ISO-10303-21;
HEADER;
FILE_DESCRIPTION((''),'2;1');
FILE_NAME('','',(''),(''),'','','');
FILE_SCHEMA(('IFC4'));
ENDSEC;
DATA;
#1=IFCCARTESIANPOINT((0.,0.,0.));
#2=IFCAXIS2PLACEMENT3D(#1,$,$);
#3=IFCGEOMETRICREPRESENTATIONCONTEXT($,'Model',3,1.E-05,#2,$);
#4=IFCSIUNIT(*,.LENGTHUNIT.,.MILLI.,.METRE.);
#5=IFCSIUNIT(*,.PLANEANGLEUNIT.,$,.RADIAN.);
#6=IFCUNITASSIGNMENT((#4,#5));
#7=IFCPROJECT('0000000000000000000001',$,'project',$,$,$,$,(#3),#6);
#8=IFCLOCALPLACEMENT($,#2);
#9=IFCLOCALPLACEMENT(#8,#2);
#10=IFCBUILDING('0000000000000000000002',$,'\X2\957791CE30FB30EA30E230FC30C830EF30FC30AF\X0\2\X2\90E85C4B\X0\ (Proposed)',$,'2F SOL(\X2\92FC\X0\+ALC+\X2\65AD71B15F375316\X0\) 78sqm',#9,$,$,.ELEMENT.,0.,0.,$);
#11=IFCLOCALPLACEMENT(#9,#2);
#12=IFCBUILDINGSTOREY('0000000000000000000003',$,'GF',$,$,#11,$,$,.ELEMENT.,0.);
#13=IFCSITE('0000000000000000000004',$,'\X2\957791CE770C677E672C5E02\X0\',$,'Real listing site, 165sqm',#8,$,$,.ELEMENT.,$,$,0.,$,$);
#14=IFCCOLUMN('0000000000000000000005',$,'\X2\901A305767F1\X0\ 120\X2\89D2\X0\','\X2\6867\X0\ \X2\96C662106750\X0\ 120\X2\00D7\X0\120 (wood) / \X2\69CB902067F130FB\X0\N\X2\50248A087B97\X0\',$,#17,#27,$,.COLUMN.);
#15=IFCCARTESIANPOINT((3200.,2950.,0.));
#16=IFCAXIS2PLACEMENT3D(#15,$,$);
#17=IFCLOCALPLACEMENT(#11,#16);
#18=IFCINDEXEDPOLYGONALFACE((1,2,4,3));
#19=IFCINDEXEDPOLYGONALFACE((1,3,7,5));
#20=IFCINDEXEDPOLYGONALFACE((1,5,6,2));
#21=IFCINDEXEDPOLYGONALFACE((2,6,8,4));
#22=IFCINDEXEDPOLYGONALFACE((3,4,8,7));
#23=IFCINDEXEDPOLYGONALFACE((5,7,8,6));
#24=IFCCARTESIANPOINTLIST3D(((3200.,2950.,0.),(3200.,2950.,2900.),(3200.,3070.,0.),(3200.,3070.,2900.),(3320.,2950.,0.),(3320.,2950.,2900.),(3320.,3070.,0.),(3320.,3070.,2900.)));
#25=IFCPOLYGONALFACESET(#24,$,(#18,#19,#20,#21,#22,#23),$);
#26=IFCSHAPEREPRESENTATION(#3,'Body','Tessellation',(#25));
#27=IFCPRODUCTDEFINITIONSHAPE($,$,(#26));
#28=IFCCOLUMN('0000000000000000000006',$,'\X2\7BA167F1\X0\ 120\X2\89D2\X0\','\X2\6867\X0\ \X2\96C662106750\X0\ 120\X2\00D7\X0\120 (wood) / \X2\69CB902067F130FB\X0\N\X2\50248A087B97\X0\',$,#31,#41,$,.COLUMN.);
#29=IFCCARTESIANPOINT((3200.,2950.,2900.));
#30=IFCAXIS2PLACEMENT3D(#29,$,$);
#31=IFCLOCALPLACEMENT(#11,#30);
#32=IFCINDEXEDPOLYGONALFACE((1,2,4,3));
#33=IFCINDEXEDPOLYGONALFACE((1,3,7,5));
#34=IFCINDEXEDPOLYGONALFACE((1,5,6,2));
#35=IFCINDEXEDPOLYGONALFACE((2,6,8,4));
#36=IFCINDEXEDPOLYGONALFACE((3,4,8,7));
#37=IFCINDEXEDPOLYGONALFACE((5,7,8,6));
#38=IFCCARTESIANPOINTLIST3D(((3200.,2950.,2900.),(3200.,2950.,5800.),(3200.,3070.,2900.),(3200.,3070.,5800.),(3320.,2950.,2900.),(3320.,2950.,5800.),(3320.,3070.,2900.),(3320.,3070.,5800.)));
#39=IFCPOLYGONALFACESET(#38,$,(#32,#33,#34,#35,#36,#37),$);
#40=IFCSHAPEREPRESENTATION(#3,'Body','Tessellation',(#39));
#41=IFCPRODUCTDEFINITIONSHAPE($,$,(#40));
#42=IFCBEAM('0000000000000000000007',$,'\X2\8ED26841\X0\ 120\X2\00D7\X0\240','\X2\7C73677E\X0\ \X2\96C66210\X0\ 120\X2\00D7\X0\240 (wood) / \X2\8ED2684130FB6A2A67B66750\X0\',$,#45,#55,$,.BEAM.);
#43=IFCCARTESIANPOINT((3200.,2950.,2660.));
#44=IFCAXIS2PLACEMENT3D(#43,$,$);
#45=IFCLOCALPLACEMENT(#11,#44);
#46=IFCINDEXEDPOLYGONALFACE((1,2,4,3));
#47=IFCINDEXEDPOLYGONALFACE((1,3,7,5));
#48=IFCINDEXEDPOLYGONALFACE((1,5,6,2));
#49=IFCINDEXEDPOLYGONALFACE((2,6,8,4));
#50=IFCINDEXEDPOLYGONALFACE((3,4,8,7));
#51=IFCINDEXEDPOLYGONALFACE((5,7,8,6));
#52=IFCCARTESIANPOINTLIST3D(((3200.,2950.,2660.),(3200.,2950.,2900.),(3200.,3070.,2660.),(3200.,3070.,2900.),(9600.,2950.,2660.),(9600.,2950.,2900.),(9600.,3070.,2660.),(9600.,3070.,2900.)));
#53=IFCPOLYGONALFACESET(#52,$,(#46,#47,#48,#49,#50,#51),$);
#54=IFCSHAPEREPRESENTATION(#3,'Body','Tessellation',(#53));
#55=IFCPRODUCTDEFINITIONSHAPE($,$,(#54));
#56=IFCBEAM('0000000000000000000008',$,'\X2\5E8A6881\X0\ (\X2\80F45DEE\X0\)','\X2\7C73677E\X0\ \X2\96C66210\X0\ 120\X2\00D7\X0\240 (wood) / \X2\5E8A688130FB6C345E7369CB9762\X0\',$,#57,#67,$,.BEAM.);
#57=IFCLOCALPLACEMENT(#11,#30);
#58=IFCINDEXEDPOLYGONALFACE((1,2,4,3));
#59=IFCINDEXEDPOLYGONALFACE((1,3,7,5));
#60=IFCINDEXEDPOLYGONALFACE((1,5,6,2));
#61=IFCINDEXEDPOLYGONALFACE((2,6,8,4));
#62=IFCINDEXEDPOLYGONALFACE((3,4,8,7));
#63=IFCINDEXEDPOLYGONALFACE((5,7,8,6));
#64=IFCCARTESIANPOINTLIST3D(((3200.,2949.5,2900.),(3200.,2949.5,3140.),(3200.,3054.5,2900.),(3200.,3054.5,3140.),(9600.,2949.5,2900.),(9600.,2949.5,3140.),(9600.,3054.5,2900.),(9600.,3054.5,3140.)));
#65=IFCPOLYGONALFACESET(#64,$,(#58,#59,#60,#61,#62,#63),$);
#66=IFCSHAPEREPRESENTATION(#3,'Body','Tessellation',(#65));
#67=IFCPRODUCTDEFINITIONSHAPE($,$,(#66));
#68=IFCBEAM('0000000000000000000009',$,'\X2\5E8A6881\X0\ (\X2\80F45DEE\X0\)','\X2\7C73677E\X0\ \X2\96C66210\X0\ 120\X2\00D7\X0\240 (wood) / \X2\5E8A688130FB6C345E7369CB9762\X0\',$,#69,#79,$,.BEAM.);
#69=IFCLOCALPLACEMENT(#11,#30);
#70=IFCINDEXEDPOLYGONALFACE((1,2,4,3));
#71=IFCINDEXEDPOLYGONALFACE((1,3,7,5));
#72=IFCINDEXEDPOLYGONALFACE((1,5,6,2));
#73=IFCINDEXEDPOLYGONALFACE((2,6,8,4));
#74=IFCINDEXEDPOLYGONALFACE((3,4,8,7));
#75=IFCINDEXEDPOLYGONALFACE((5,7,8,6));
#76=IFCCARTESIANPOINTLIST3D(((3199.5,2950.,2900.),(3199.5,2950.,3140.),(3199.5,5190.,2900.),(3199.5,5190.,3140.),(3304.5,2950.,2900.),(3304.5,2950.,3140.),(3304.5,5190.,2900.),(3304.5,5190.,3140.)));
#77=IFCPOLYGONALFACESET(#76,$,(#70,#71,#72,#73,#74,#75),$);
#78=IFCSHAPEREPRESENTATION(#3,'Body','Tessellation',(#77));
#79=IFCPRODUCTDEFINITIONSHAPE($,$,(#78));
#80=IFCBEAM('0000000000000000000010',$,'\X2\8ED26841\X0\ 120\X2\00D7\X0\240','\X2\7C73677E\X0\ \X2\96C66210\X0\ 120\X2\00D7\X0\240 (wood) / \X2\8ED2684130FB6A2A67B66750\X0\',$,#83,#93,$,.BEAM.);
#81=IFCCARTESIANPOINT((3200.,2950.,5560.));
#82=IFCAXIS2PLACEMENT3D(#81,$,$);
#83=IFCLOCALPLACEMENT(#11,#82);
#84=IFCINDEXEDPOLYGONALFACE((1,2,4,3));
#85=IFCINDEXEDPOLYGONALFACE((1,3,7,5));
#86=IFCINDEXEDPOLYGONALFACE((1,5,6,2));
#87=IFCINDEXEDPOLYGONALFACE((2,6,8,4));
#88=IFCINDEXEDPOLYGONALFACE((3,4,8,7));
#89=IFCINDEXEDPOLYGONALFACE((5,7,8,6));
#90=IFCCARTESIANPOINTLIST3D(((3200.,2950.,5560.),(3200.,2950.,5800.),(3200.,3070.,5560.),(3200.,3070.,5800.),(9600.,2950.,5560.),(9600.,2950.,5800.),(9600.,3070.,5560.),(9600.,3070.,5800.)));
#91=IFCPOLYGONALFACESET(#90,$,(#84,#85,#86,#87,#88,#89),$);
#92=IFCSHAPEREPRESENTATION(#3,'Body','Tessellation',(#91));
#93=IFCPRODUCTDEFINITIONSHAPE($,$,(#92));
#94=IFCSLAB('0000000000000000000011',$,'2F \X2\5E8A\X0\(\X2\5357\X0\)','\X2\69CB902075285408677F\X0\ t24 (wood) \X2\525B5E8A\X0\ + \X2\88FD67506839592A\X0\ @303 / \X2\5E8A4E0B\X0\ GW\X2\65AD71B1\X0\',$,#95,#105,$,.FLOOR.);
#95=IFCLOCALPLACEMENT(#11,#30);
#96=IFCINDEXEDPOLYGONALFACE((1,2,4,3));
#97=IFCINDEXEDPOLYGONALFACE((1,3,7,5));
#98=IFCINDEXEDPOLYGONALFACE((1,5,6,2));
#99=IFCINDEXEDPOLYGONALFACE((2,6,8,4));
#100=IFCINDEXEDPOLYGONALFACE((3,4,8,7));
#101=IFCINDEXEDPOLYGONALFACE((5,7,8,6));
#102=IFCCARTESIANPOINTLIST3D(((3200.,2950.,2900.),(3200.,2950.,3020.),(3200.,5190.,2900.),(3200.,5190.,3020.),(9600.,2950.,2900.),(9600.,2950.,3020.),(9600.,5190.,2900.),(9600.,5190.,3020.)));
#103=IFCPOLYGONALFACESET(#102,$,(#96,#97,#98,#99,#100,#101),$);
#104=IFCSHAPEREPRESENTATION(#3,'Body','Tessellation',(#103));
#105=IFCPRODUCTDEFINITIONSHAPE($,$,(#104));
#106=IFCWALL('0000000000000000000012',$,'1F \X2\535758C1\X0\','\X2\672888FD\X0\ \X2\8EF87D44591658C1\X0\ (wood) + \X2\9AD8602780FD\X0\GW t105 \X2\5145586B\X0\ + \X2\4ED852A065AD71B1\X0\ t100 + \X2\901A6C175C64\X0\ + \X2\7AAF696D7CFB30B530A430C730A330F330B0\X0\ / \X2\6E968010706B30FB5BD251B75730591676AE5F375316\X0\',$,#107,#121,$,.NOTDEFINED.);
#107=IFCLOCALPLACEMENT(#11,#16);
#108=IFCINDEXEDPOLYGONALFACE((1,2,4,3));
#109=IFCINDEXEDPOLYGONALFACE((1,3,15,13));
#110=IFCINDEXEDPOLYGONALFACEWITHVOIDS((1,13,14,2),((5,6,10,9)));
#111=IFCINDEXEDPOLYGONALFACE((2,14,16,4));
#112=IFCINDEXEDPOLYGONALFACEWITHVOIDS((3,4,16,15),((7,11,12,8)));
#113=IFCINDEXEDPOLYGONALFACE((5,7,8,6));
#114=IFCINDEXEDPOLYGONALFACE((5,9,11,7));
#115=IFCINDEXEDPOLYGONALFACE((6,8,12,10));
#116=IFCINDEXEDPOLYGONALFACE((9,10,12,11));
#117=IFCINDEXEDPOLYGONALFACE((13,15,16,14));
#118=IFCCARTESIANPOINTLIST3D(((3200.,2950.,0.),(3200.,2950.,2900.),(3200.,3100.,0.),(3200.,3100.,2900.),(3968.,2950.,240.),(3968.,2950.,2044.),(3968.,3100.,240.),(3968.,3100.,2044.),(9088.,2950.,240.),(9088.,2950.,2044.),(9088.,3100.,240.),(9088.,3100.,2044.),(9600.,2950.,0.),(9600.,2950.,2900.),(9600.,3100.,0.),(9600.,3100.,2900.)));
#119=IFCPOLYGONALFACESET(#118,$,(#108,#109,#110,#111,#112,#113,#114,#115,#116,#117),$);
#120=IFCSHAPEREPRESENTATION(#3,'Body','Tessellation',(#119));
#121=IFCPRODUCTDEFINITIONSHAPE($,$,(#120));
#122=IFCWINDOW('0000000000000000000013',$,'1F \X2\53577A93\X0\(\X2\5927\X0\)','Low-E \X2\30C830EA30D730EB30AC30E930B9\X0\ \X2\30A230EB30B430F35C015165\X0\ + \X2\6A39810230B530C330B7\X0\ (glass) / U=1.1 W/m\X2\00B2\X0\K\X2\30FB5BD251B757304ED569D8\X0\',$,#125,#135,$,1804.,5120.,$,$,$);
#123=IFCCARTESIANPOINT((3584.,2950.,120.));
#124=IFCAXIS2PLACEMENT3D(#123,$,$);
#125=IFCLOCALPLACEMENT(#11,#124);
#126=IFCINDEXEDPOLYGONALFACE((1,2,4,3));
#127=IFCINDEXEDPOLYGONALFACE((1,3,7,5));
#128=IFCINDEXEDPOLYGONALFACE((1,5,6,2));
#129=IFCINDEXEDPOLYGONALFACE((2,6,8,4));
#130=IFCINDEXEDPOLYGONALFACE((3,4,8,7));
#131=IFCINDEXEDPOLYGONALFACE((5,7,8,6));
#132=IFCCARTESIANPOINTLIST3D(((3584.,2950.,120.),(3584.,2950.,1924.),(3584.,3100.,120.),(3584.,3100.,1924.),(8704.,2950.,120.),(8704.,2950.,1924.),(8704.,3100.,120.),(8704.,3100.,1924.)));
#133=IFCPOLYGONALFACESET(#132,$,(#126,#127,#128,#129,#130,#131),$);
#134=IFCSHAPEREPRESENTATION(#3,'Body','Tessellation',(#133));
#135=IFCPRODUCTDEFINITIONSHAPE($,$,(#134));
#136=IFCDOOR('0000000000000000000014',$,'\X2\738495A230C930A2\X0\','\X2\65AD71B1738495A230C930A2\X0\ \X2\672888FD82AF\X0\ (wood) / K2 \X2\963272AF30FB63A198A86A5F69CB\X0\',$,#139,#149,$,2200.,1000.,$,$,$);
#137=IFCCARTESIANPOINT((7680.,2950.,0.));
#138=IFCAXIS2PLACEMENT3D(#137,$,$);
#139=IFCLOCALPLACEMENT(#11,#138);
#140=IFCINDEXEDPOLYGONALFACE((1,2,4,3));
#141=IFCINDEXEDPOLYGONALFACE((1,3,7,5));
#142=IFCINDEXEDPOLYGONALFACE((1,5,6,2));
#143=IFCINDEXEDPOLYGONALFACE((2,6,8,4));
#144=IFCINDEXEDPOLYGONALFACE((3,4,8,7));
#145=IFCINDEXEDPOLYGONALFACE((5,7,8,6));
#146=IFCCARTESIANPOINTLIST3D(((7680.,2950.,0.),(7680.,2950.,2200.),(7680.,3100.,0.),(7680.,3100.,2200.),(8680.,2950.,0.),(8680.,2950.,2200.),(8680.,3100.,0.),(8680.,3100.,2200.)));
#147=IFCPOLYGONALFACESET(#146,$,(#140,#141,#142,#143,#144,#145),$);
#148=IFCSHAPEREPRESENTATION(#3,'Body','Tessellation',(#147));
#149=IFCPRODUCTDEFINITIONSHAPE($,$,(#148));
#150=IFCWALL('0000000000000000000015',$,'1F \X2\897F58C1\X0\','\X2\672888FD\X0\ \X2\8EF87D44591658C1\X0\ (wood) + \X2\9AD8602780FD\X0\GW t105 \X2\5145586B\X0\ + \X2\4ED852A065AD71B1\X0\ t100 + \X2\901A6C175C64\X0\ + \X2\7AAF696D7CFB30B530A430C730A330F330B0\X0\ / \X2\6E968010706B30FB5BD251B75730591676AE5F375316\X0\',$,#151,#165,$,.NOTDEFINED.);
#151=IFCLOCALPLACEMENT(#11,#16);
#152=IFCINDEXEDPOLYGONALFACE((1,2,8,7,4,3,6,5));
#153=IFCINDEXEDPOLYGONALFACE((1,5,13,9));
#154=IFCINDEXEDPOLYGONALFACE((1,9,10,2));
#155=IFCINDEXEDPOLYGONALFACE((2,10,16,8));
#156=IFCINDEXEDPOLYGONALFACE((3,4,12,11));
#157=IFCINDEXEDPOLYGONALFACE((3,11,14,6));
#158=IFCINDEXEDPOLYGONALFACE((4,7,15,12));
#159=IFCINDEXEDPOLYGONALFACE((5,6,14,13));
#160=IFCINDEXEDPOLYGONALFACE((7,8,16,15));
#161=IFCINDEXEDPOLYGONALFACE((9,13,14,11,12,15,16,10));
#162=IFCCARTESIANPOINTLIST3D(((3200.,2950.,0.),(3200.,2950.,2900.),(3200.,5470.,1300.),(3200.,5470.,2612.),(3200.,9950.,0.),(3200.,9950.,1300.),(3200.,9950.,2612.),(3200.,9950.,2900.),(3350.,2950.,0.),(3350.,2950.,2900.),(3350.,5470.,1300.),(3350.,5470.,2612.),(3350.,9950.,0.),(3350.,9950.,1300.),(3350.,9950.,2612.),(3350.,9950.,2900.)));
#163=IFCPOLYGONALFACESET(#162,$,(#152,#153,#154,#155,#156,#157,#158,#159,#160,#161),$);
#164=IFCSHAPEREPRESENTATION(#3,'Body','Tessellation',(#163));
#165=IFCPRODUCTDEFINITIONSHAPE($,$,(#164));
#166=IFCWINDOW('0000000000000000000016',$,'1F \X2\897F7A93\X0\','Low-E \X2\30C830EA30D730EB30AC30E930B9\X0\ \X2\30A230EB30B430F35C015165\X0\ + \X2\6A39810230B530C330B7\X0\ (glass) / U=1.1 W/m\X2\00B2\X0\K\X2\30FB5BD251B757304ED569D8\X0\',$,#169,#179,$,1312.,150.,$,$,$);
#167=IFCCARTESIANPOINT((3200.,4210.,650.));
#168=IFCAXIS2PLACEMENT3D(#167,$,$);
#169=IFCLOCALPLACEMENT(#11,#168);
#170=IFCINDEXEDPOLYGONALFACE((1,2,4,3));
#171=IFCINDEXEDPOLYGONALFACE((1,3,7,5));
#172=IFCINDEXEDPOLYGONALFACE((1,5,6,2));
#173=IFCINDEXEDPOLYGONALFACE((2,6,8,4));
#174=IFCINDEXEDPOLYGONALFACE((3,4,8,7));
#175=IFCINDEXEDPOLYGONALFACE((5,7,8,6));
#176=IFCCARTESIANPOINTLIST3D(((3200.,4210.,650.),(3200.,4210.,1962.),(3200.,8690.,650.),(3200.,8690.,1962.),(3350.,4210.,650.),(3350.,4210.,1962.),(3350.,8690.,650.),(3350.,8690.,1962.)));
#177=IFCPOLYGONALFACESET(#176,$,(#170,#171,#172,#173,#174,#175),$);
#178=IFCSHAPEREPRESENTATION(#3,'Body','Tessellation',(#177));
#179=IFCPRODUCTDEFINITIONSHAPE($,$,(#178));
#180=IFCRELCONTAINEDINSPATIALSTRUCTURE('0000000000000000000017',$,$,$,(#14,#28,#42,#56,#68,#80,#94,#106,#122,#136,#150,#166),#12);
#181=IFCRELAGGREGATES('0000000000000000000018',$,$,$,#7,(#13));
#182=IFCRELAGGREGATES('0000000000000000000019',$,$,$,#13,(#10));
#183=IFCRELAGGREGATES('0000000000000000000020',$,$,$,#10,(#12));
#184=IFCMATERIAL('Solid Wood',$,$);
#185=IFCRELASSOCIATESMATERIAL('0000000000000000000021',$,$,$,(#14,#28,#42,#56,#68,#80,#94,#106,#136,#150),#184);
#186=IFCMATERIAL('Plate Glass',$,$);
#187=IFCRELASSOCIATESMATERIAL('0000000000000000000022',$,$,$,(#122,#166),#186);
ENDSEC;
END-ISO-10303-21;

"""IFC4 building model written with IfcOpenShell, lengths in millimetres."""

from ifc_helpers import new_model, si_unit, frame, frame_2d, origin, place, context, project, spatial, rectangle, extrude, material, element, fill, save


model = new_model("IFC4")

# Units and contexts
model_context = context("Model", 3, precision=1e-05, world=origin())
ifc_project = project(units=[si_unit("LENGTHUNIT", "METRE", prefix="MILLI"), si_unit("PLANEANGLEUNIT", "RADIAN")], contexts=[model_context])

# Site, building, storey
site_placement = place(None, origin())
site = spatial("IfcSite", under=ifc_project, at=site_placement, Name="長野県松本市", ObjectType="Real listing site, 165sqm", CompositionType="ELEMENT", RefElevation=0.0)
building_placement = place(site_placement, origin())
building = spatial("IfcBuilding", under=site, at=building_placement, Name="長野・リモートワーク2部屋 (Proposed)", ObjectType="2F SOL(鋼+ALC+断熱強化) 78sqm", CompositionType="ELEMENT", ElevationOfRefHeight=0.0, ElevationOfTerrain=0.0)
storey_placement = place(building_placement, origin())
storey = spatial("IfcBuildingStorey", under=building, at=storey_placement, Name="GF", CompositionType="ELEMENT", Elevation=0.0)

# Columns
ifc_material_1 = material(Name="Solid Wood")
column_1_placement = place(storey_placement, frame((3200.0, 2950.0, 0.0)))
element("IfcColumn", 1, at=column_1_placement, inside=storey, material=ifc_material_1, Name="通し柱 120角", Description="桧 集成材 120×120 (wood) / 構造柱・N値計算", PredefinedType="COLUMN", context=model_context, shape_type="SweptSolid", body=[
    extrude(rectangle(XDim=120.0, YDim=120.0, at=frame_2d((60.0, 60.0))), frame((3200.0, 2950.0, 0.0)), (0.0, 0.0, 1.0), 2900.0),
])
column_2_placement = place(storey_placement, frame((3200.0, 2950.0, 2900.0)))
element("IfcColumn", 2, at=column_2_placement, inside=storey, material=ifc_material_1, Name="管柱 120角", Description="桧 集成材 120×120 (wood) / 構造柱・N値計算", PredefinedType="COLUMN", context=model_context, shape_type="SweptSolid", body=[
    extrude(rectangle(XDim=120.0, YDim=120.0, at=frame_2d((60.0, 60.0))), frame((3200.0, 2950.0, 2900.0)), (0.0, 0.0, 1.0), 2900.0),
])

# Beams
beam_1_placement = place(storey_placement, frame((3200.0, 2950.0, 2660.0)))
element("IfcBeam", 3, at=beam_1_placement, inside=storey, material=ifc_material_1, Name="軒桁 120×240", Description="米松 集成 120×240 (wood) / 軒桁・横架材", PredefinedType="BEAM", context=model_context, shape_type="SweptSolid", body=[
    extrude(rectangle(XDim=6400.0, YDim=120.0, at=frame_2d((3200.0, 60.0))), frame((3200.0, 2950.0, 2660.0)), (0.0, 0.0, 1.0), 240.0),
])
beam_2_placement = place(storey_placement, frame((3200.0, 2950.0, 2900.0)))
element("IfcBeam", 4, at=beam_2_placement, inside=storey, material=ifc_material_1, Name="床梁 (胴差)", Description="米松 集成 120×240 (wood) / 床梁・水平構面", PredefinedType="BEAM", context=model_context, shape_type="SweptSolid", body=[
    extrude(rectangle(XDim=6400.0, YDim=105.0, at=frame_2d((3200.0, 52.0))), frame((3200.0, 2950.0, 2900.0)), (0.0, 0.0, 1.0), 240.0),
])
beam_3_placement = place(storey_placement, frame((3200.0, 2950.0, 2900.0)))
element("IfcBeam", 5, at=beam_3_placement, inside=storey, material=ifc_material_1, Name="床梁 (胴差)", Description="米松 集成 120×240 (wood) / 床梁・水平構面", PredefinedType="BEAM", context=model_context, shape_type="SweptSolid", body=[
    extrude(rectangle(XDim=105.0, YDim=2240.0, at=frame_2d((52.0, 1120.0))), frame((3200.0, 2950.0, 2900.0)), (0.0, 0.0, 1.0), 240.0),
])
beam_4_placement = place(storey_placement, frame((3200.0, 2950.0, 5560.0)))
element("IfcBeam", 6, at=beam_4_placement, inside=storey, material=ifc_material_1, Name="軒桁 120×240", Description="米松 集成 120×240 (wood) / 軒桁・横架材", PredefinedType="BEAM", context=model_context, shape_type="SweptSolid", body=[
    extrude(rectangle(XDim=6400.0, YDim=120.0, at=frame_2d((3200.0, 60.0))), frame((3200.0, 2950.0, 5560.0)), (0.0, 0.0, 1.0), 240.0),
])

# Slab
slab_1_placement = place(storey_placement, frame((3200.0, 2950.0, 2900.0)))
element("IfcSlab", 7, at=slab_1_placement, inside=storey, material=ifc_material_1, Name="2F 床(南)", Description="構造用合板 t24 (wood) 剛床 + 製材根太 @303 / 床下 GW断熱", PredefinedType="FLOOR", context=model_context, shape_type="SweptSolid", body=[
    extrude(rectangle(XDim=6400.0, YDim=2240.0, at=frame_2d((3200.0, 1120.0))), frame((3200.0, 2950.0, 2900.0)), (0.0, 0.0, 1.0), 120.0),
])

# Wall, openings, window, door
wall_1_placement = place(storey_placement, frame((3200.0, 2950.0, 0.0)))
wall_1 = element("IfcWall", 8, at=wall_1_placement, inside=storey, material=ifc_material_1, Name="1F 南壁", Description="木製 軸組外壁 (wood) + 高性能GW t105 充填 + 付加断熱 t100 + 通気層 + 窯業系サイディング / 準耐火・寒冷地外皮強化", PredefinedType="NOTDEFINED", context=model_context, shape_type="SweptSolid", body=[
    extrude(rectangle(XDim=6400.0, YDim=150.0, at=frame_2d((3200.0, 75.0))), frame((3200.0, 2950.0, 0.0)), (0.0, 0.0, 1.0), 2900.0),
])
opening_1_placement = place(storey_placement, frame((3584.0, 2950.0, 120.0)))
opening_1 = element("IfcOpeningElement", 9, at=opening_1_placement, cuts=wall_1, PredefinedType="NOTDEFINED", context=model_context, shape_type="SweptSolid", body=[
    extrude(rectangle(XDim=5120.0, YDim=150.0, at=frame_2d((2560.0, 75.0))), frame((3584.0, 2950.0, 120.0)), (0.0, 0.0, 1.0), 1804.0),
])
opening_2_placement = place(storey_placement, frame((7680.0, 2950.0, 0.0)))
opening_2 = element("IfcOpeningElement", 10, at=opening_2_placement, cuts=wall_1, PredefinedType="NOTDEFINED", context=model_context, shape_type="SweptSolid", body=[
    extrude(rectangle(XDim=1000.0, YDim=150.0, at=frame_2d((500.0, 75.0))), frame((7680.0, 2950.0, 0.0)), (0.0, 0.0, 1.0), 2200.0),
])
ifc_material_2 = material(Name="Plate Glass")
window_1_placement = place(storey_placement, frame((3584.0, 2950.0, 120.0)))
window_1 = element("IfcWindow", 11, at=window_1_placement, inside=storey, material=ifc_material_2, Name="1F 南窓(大)", Description="Low-E トリプルガラス アルゴン封入 + 樹脂サッシ (glass) / U=1.1 W/m²K・寒冷地仕様", OverallHeight=1804.0, OverallWidth=5120.0, context=model_context, shape_type="SweptSolid", body=[
    extrude(rectangle(XDim=5120.0, YDim=150.0, at=frame_2d((2560.0, 75.0))), frame((3584.0, 2950.0, 120.0)), (0.0, 0.0, 1.0), 1804.0),
])
fill(opening_1, window_1)
door_placement = place(storey_placement, frame((7680.0, 2950.0, 0.0)))
door = element("IfcDoor", 12, at=door_placement, inside=storey, material=ifc_material_1, Name="玄関ドア", Description="断熱玄関ドア 木製芯 (wood) / K2 防犯・採風機構", OverallHeight=2200.0, OverallWidth=1000.0, context=model_context, shape_type="SweptSolid", body=[
    extrude(rectangle(XDim=1000.0, YDim=150.0, at=frame_2d((500.0, 75.0))), frame((7680.0, 2950.0, 0.0)), (0.0, 0.0, 1.0), 2200.0),
])
fill(opening_2, door)

# Wall, opening, window
wall_2_placement = place(storey_placement, frame((3200.0, 2950.0, 0.0)))
wall_2 = element("IfcWall", 13, at=wall_2_placement, inside=storey, material=ifc_material_1, Name="1F 西壁", Description="木製 軸組外壁 (wood) + 高性能GW t105 充填 + 付加断熱 t100 + 通気層 + 窯業系サイディング / 準耐火・寒冷地外皮強化", PredefinedType="NOTDEFINED", context=model_context, shape_type="SweptSolid", body=[
    extrude(rectangle(XDim=150.0, YDim=7000.0, at=frame_2d((75.0, 3500.0))), frame((3200.0, 2950.0, 0.0)), (0.0, 0.0, 1.0), 2900.0),
])
opening_3_placement = place(storey_placement, frame((3200.0, 4210.0, 650.0)))
opening_3 = element("IfcOpeningElement", 14, at=opening_3_placement, cuts=wall_2, PredefinedType="NOTDEFINED", context=model_context, shape_type="SweptSolid", body=[
    extrude(rectangle(XDim=150.0, YDim=4480.0, at=frame_2d((75.0, 2240.0))), frame((3200.0, 4210.0, 650.0)), (0.0, 0.0, 1.0), 1312.0),
])
window_2_placement = place(storey_placement, frame((3200.0, 4210.0, 650.0)))
window_2 = element("IfcWindow", 15, at=window_2_placement, inside=storey, material=ifc_material_2, Name="1F 西窓", Description="Low-E トリプルガラス アルゴン封入 + 樹脂サッシ (glass) / U=1.1 W/m²K・寒冷地仕様", OverallHeight=1312.0, OverallWidth=150.0, context=model_context, shape_type="SweptSolid", body=[
    extrude(rectangle(XDim=150.0, YDim=4480.0, at=frame_2d((75.0, 2240.0))), frame((3200.0, 4210.0, 650.0)), (0.0, 0.0, 1.0), 1312.0),
])
fill(opening_3, window_2)

save(model, "model.ifc")
